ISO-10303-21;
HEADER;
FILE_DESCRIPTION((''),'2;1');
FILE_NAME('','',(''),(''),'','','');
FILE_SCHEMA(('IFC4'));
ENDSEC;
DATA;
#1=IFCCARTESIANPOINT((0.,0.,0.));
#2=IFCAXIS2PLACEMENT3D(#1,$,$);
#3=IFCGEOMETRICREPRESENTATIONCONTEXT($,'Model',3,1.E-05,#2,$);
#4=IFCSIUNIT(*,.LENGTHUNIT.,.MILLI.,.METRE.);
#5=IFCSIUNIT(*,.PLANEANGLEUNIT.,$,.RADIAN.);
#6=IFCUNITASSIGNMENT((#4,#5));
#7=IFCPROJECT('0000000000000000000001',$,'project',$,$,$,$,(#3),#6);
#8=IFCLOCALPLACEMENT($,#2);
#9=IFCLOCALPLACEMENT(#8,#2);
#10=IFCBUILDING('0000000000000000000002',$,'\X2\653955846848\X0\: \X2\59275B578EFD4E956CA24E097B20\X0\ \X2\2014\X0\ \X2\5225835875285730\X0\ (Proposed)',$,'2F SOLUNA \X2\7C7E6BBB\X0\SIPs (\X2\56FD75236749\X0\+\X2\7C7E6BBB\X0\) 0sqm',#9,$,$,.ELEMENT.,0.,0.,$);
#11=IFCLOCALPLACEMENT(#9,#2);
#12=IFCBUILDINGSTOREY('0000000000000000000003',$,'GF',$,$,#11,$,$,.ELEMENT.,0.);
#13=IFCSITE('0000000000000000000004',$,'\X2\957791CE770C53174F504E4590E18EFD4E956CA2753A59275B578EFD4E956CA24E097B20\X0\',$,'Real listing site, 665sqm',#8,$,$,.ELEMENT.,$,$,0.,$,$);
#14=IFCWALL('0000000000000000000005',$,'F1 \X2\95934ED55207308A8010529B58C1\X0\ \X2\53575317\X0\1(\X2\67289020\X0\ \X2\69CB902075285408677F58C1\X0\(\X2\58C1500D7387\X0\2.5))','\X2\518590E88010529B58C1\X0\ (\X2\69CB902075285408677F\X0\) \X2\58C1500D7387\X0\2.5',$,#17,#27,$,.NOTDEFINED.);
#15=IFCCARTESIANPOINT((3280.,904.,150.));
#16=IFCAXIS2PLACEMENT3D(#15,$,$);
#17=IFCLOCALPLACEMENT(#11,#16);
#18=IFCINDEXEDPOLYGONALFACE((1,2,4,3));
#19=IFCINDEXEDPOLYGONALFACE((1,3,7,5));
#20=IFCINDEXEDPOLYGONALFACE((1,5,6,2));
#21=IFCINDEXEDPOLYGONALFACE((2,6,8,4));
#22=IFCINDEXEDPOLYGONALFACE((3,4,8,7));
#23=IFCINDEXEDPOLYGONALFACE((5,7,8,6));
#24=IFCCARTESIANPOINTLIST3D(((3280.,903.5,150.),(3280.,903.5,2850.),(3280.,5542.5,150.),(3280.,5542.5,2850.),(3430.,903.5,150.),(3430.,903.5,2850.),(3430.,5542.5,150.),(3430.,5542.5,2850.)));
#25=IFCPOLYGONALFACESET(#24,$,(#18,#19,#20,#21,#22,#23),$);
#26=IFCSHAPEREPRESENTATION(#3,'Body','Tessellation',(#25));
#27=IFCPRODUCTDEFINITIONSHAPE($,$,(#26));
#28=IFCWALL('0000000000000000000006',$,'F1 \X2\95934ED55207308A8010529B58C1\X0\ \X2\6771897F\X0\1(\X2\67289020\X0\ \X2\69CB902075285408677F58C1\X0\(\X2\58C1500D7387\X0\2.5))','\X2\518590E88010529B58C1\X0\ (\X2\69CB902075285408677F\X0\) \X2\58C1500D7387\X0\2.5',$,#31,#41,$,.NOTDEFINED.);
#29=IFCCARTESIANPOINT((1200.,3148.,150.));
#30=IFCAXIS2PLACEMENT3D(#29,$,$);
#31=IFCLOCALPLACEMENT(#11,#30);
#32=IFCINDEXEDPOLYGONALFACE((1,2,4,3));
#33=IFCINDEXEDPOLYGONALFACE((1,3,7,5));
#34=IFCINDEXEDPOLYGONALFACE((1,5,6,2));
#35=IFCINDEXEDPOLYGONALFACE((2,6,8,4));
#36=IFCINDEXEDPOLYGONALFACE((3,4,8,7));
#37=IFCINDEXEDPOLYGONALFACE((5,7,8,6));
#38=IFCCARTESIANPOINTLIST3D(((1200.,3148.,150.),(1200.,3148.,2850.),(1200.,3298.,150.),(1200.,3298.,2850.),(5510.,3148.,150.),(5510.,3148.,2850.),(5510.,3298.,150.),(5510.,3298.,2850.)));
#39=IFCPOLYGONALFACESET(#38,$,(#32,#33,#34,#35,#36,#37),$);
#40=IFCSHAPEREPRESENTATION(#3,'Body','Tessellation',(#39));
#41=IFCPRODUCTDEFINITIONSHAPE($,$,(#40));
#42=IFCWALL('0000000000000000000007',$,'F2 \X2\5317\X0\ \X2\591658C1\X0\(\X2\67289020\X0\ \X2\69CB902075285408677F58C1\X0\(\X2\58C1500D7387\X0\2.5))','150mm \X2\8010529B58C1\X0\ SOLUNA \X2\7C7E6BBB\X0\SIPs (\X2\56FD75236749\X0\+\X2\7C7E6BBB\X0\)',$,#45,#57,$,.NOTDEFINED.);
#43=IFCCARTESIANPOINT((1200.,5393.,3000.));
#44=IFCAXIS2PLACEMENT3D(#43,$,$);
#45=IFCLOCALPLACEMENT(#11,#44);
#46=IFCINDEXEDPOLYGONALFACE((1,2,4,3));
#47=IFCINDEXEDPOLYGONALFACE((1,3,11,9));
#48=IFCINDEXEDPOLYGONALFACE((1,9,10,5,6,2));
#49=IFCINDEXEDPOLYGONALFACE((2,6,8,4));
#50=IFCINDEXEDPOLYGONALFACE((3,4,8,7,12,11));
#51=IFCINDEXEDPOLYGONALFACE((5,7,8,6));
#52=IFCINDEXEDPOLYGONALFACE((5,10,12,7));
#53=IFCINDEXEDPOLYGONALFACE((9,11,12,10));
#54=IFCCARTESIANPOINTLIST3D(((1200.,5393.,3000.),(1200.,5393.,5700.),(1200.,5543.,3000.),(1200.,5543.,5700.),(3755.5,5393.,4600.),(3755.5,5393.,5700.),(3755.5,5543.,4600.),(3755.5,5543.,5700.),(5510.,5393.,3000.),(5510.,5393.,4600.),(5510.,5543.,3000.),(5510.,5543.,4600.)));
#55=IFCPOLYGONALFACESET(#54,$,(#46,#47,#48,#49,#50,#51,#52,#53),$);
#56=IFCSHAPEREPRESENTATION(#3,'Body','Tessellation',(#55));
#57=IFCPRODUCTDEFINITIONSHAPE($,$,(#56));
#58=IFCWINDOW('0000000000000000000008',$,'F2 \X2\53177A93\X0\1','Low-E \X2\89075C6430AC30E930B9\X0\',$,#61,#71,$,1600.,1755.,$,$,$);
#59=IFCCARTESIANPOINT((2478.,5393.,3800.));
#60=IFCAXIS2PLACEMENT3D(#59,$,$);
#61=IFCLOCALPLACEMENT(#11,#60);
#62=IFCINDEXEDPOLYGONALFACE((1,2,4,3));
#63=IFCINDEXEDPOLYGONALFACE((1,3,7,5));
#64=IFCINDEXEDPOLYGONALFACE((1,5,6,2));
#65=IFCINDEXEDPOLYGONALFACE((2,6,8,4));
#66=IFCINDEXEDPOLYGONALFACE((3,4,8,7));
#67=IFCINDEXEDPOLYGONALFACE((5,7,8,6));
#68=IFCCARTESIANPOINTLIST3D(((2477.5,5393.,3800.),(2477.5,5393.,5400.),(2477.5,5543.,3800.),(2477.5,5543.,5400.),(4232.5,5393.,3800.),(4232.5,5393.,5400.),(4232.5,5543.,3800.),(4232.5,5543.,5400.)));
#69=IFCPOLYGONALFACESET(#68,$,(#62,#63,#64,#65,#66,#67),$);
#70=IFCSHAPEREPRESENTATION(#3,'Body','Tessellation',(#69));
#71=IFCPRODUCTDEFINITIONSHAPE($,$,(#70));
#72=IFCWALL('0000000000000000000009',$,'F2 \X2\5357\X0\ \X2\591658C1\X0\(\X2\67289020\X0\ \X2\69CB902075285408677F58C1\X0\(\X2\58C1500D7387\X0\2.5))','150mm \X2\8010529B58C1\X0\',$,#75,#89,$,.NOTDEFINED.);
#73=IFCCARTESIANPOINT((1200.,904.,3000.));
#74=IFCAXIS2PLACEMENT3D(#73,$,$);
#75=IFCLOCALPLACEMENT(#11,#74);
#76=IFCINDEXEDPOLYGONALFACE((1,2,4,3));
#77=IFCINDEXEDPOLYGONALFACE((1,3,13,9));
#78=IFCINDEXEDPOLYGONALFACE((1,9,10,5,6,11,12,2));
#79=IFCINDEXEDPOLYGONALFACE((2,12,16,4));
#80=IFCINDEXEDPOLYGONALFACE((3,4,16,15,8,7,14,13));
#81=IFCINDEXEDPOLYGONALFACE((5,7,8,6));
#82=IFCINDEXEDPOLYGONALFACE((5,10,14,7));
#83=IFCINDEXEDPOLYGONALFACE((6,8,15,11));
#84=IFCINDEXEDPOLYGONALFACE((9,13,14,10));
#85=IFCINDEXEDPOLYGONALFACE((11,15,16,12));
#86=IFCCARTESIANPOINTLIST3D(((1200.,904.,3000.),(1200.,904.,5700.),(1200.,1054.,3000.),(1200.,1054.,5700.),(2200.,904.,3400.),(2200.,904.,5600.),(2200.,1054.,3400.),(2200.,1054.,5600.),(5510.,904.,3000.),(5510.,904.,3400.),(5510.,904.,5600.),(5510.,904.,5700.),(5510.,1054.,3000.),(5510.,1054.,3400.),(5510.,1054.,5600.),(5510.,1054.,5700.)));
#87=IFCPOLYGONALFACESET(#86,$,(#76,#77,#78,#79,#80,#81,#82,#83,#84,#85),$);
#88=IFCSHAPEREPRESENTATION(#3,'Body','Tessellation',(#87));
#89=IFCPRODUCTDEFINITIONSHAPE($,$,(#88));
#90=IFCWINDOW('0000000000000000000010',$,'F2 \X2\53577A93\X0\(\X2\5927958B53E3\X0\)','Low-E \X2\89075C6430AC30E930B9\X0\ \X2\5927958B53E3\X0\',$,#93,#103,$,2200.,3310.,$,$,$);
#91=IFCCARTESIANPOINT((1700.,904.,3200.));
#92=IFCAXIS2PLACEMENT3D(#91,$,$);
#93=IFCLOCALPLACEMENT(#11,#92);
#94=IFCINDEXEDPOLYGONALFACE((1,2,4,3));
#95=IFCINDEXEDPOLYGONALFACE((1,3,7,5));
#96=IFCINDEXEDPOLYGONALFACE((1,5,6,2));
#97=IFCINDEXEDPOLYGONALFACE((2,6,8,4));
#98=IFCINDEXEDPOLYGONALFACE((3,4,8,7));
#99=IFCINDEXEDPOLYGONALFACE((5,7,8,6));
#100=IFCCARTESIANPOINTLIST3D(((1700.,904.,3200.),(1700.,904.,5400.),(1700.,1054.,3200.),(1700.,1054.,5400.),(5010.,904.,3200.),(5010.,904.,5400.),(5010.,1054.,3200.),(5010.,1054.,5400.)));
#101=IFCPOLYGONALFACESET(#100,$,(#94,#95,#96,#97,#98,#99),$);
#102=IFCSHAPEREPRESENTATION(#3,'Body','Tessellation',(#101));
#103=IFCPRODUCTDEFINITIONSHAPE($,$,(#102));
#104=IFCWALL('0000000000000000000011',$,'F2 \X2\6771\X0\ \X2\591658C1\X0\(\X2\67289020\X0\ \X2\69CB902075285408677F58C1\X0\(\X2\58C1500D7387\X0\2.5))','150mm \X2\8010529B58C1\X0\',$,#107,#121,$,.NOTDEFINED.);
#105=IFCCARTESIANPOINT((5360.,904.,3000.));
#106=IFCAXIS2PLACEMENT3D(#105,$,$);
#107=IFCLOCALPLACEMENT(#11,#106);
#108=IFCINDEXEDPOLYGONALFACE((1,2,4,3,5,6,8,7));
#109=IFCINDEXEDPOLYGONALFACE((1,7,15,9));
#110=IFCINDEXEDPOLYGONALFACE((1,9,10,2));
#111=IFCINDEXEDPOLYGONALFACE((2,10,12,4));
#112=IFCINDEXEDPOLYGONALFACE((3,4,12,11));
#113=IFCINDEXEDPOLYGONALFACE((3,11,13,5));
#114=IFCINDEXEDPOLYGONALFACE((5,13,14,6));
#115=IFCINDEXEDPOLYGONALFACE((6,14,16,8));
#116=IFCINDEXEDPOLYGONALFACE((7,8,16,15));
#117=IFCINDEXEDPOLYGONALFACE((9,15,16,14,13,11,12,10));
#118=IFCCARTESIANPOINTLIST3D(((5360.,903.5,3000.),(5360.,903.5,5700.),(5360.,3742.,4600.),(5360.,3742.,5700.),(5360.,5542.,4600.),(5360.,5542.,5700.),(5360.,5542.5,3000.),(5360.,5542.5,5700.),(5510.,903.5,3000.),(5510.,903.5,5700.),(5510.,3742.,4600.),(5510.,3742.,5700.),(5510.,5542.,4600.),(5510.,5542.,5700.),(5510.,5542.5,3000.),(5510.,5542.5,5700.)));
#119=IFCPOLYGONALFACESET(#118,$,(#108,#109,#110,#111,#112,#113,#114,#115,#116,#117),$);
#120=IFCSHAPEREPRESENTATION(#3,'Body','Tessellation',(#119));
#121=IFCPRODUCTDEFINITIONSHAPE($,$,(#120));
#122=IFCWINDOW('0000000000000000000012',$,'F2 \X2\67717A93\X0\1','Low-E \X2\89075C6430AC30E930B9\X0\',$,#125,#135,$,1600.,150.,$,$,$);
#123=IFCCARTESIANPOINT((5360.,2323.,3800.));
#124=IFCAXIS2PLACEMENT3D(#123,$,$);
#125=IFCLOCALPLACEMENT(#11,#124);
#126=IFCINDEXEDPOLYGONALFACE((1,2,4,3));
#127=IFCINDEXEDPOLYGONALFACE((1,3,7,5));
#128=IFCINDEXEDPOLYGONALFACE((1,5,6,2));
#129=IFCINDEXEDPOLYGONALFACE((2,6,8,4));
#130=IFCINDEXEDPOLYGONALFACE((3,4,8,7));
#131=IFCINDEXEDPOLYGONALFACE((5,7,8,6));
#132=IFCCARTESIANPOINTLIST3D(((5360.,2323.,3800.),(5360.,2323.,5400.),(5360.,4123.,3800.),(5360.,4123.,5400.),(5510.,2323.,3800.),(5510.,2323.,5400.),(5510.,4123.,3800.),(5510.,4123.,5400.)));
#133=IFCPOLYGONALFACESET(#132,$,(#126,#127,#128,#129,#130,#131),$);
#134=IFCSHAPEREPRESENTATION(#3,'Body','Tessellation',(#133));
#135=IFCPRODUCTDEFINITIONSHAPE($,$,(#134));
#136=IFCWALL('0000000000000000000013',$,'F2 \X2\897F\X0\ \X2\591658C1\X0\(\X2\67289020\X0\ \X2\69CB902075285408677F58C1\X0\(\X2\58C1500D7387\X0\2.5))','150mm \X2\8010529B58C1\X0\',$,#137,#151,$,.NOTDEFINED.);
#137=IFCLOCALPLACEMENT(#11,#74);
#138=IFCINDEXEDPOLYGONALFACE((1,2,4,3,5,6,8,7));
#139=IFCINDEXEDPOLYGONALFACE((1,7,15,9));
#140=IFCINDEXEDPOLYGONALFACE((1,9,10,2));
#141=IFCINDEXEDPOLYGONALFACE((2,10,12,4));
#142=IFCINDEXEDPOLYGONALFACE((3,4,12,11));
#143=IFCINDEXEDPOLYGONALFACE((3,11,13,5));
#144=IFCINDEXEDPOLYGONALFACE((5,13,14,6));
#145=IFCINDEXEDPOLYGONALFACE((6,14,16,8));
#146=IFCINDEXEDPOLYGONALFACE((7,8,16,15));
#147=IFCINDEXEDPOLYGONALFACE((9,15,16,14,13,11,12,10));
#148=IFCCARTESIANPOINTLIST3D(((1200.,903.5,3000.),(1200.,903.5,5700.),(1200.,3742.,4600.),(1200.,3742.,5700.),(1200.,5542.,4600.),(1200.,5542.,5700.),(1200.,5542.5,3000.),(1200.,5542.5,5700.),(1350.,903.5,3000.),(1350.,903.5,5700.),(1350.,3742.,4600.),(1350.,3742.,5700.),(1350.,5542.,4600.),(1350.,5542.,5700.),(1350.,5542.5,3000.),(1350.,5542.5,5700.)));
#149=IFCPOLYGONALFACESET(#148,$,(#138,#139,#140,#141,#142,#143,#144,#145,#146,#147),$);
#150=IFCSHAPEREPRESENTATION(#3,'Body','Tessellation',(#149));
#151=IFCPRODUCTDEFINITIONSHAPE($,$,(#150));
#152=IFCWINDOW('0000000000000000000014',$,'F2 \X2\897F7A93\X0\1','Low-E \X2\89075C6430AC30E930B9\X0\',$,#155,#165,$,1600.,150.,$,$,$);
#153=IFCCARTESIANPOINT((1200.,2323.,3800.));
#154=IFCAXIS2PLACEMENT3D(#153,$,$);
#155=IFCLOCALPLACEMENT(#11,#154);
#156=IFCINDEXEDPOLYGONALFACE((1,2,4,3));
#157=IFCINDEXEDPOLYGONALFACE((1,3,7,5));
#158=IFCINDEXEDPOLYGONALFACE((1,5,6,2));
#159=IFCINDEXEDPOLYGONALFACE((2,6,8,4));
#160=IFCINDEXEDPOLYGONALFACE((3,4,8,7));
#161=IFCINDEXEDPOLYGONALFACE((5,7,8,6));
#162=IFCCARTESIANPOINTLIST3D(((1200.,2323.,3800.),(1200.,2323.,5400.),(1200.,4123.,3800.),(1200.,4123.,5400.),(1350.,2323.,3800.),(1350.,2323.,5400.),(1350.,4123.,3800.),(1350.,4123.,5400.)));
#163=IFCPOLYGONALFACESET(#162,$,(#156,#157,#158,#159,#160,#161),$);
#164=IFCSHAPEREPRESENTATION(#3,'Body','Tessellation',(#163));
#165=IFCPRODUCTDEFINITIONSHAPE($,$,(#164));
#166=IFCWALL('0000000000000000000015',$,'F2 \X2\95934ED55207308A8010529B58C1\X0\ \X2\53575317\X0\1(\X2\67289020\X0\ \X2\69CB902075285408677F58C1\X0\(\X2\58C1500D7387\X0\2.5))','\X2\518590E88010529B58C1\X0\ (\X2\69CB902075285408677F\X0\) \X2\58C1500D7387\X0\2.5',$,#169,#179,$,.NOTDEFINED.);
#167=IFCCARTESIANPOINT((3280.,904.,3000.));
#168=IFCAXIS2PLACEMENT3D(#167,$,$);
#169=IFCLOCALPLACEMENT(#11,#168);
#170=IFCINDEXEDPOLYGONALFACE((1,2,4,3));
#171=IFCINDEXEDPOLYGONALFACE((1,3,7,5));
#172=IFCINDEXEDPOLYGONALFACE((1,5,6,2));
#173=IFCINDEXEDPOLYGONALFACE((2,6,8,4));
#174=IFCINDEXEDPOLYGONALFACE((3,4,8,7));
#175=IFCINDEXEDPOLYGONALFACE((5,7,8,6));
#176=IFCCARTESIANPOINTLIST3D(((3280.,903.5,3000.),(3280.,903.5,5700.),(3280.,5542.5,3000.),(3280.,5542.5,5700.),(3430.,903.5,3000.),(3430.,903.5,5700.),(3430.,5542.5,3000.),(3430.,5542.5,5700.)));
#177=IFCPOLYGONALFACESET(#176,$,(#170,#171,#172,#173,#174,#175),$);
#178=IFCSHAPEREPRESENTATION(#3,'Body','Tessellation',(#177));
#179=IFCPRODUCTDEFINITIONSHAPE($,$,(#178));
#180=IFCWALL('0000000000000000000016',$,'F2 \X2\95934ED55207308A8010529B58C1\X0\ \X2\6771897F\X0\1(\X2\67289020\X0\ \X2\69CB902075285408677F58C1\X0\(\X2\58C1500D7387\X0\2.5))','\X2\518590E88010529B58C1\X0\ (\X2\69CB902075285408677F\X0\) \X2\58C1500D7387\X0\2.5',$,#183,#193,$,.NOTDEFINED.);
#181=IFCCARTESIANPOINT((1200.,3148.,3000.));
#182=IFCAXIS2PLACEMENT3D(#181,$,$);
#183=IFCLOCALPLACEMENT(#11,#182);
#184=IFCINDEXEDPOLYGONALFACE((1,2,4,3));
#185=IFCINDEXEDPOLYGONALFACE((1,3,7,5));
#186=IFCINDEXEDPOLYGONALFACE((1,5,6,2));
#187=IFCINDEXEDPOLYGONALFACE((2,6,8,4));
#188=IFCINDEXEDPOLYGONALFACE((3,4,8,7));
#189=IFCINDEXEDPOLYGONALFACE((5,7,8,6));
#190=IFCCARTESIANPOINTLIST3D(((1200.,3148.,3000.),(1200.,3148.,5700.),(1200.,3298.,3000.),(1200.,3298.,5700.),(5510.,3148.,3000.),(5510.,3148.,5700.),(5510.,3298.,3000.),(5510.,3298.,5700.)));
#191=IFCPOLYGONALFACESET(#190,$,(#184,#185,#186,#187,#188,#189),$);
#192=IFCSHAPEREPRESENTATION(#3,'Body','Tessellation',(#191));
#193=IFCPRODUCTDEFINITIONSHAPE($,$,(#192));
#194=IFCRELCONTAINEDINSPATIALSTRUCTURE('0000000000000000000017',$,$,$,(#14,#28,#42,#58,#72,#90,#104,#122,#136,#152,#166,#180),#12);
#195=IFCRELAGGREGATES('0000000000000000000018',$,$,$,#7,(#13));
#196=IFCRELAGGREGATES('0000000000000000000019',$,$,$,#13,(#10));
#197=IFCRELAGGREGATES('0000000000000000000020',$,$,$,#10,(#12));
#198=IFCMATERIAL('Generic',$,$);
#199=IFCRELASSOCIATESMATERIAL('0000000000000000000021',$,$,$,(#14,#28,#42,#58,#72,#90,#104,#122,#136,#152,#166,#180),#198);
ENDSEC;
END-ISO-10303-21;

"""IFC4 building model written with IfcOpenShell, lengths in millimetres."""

from ifc_helpers import new_model, si_unit, frame, frame_2d, origin, place, context, project, spatial, rectangle, extrude, material, element, fill, save


model = new_model("IFC4")

# Units and contexts
model_context = context("Model", 3, precision=1e-05, world=origin())
ifc_project = project(units=[si_unit("LENGTHUNIT", "METRE", prefix="MILLI"), si_unit("PLANEANGLEUNIT", "RADIAN")], contexts=[model_context])

# Site, building, storey
site_placement = place(None, origin())
site = spatial("IfcSite", under=ifc_project, at=site_placement, Name="長野県北佐久郡軽井沢町大字軽井沢三笠", ObjectType="Real listing site, 665sqm", CompositionType="ELEMENT", RefElevation=0.0)
building_placement = place(site_placement, origin())
building = spatial("IfcBuilding", under=site, at=building_placement, Name="改善案: 大字軽井沢三笠 — 別荘用地 (Proposed)", ObjectType="2F SOLUNA 籾殻SIPs (国産杉+籾殻) 0sqm", CompositionType="ELEMENT", ElevationOfRefHeight=0.0, ElevationOfTerrain=0.0)
storey_placement = place(building_placement, origin())
storey = spatial("IfcBuildingStorey", under=building, at=storey_placement, Name="GF", CompositionType="ELEMENT", Elevation=0.0)

# Shared definitions
ifc_material_1 = material(Name="Generic")

# Walls
wall_1_placement = place(storey_placement, frame((3280.0, 904.0, 150.0)))
element("IfcWall", 1, at=wall_1_placement, inside=storey, material=ifc_material_1, Name="F1 間仕切り耐力壁 南北1(木造 構造用合板壁(壁倍率2.5))", Description="内部耐力壁 (構造用合板) 壁倍率2.5", PredefinedType="NOTDEFINED", context=model_context, shape_type="SweptSolid", body=[
    extrude(rectangle(XDim=150.0, YDim=4639.0, at=frame_2d((75.0, 2319.0))), frame((3280.0, 904.0, 150.0)), (0.0, 0.0, 1.0), 2700.0),
])
wall_2_placement = place(storey_placement, frame((1200.0, 3148.0, 150.0)))
element("IfcWall", 2, at=wall_2_placement, inside=storey, material=ifc_material_1, Name="F1 間仕切り耐力壁 東西1(木造 構造用合板壁(壁倍率2.5))", Description="内部耐力壁 (構造用合板) 壁倍率2.5", PredefinedType="NOTDEFINED", context=model_context, shape_type="SweptSolid", body=[
    extrude(rectangle(XDim=4310.0, YDim=150.0, at=frame_2d((2155.0, 75.0))), frame((1200.0, 3148.0, 150.0)), (0.0, 0.0, 1.0), 2700.0),
])

# Walls, openings, windows
wall_3_placement = place(storey_placement, frame((1200.0, 5393.0, 3000.0)))
wall_3 = element("IfcWall", 3, at=wall_3_placement, inside=storey, material=ifc_material_1, Name="F2 北 外壁(木造 構造用合板壁(壁倍率2.5))", Description="150mm 耐力壁 SOLUNA 籾殻SIPs (国産杉+籾殻)", PredefinedType="NOTDEFINED", context=model_context, shape_type="SweptSolid", body=[
    extrude(rectangle(XDim=4310.0, YDim=150.0, at=frame_2d((2155.0, 75.0))), frame((1200.0, 5393.0, 3000.0)), (0.0, 0.0, 1.0), 2700.0),
])
opening_1_placement = place(storey_placement, frame((2478.0, 5393.0, 3800.0)))
opening_1 = element("IfcOpeningElement", 4, at=opening_1_placement, cuts=wall_3, PredefinedType="NOTDEFINED", context=model_context, shape_type="SweptSolid", body=[
    extrude(rectangle(XDim=1755.0, YDim=150.0, at=frame_2d((877.0, 75.0))), frame((2478.0, 5393.0, 3800.0)), (0.0, 0.0, 1.0), 1600.0),
])
window_1_placement = place(storey_placement, frame((2478.0, 5393.0, 3800.0)))
window_1 = element("IfcWindow", 5, at=window_1_placement, inside=storey, material=ifc_material_1, Name="F2 北窓1", Description="Low-E 複層ガラス", OverallHeight=1600.0, OverallWidth=1755.0, context=model_context, shape_type="SweptSolid", body=[
    extrude(rectangle(XDim=1755.0, YDim=150.0, at=frame_2d((877.0, 75.0))), frame((2478.0, 5393.0, 3800.0)), (0.0, 0.0, 1.0), 1600.0),
])
fill(opening_1, window_1)
wall_4_placement = place(storey_placement, frame((1200.0, 904.0, 3000.0)))
wall_4 = element("IfcWall", 6, at=wall_4_placement, inside=storey, material=ifc_material_1, Name="F2 南 外壁(木造 構造用合板壁(壁倍率2.5))", Description="150mm 耐力壁", PredefinedType="NOTDEFINED", context=model_context, shape_type="SweptSolid", body=[
    extrude(rectangle(XDim=4310.0, YDim=150.0, at=frame_2d((2155.0, 75.0))), frame((1200.0, 904.0, 3000.0)), (0.0, 0.0, 1.0), 2700.0),
])
opening_2_placement = place(storey_placement, frame((1700.0, 904.0, 3200.0)))
opening_2 = element("IfcOpeningElement", 7, at=opening_2_placement, cuts=wall_4, PredefinedType="NOTDEFINED", context=model_context, shape_type="SweptSolid", body=[
    extrude(rectangle(XDim=3310.0, YDim=150.0, at=frame_2d((1655.0, 75.0))), frame((1700.0, 904.0, 3200.0)), (0.0, 0.0, 1.0), 2200.0),
])
window_2_placement = place(storey_placement, frame((1700.0, 904.0, 3200.0)))
window_2 = element("IfcWindow", 8, at=window_2_placement, inside=storey, material=ifc_material_1, Name="F2 南窓(大開口)", Description="Low-E 複層ガラス 大開口", OverallHeight=2200.0, OverallWidth=3310.0, context=model_context, shape_type="SweptSolid", body=[
    extrude(rectangle(XDim=3310.0, YDim=150.0, at=frame_2d((1655.0, 75.0))), frame((1700.0, 904.0, 3200.0)), (0.0, 0.0, 1.0), 2200.0),
])
fill(opening_2, window_2)
wall_5_placement = place(storey_placement, frame((5360.0, 904.0, 3000.0)))
wall_5 = element("IfcWall", 9, at=wall_5_placement, inside=storey, material=ifc_material_1, Name="F2 東 外壁(木造 構造用合板壁(壁倍率2.5))", Description="150mm 耐力壁", PredefinedType="NOTDEFINED", context=model_context, shape_type="SweptSolid", body=[
    extrude(rectangle(XDim=150.0, YDim=4639.0, at=frame_2d((75.0, 2319.0))), frame((5360.0, 904.0, 3000.0)), (0.0, 0.0, 1.0), 2700.0),
])
opening_3_placement = place(storey_placement, frame((5360.0, 2323.0, 3800.0)))
opening_3 = element("IfcOpeningElement", 10, at=opening_3_placement, cuts=wall_5, PredefinedType="NOTDEFINED", context=model_context, shape_type="SweptSolid", body=[
    extrude(rectangle(XDim=150.0, YDim=1800.0, at=frame_2d((75.0, 900.0))), frame((5360.0, 2323.0, 3800.0)), (0.0, 0.0, 1.0), 1600.0),
])
window_3_placement = place(storey_placement, frame((5360.0, 2323.0, 3800.0)))
window_3 = element("IfcWindow", 11, at=window_3_placement, inside=storey, material=ifc_material_1, Name="F2 東窓1", Description="Low-E 複層ガラス", OverallHeight=1600.0, OverallWidth=150.0, context=model_context, shape_type="SweptSolid", body=[
    extrude(rectangle(XDim=150.0, YDim=1800.0, at=frame_2d((75.0, 900.0))), frame((5360.0, 2323.0, 3800.0)), (0.0, 0.0, 1.0), 1600.0),
])
fill(opening_3, window_3)
wall_6_placement = place(storey_placement, frame((1200.0, 904.0, 3000.0)))
wall_6 = element("IfcWall", 12, at=wall_6_placement, inside=storey, material=ifc_material_1, Name="F2 西 外壁(木造 構造用合板壁(壁倍率2.5))", Description="150mm 耐力壁", PredefinedType="NOTDEFINED", context=model_context, shape_type="SweptSolid", body=[
    extrude(rectangle(XDim=150.0, YDim=4639.0, at=frame_2d((75.0, 2319.0))), frame((1200.0, 904.0, 3000.0)), (0.0, 0.0, 1.0), 2700.0),
])
opening_4_placement = place(storey_placement, frame((1200.0, 2323.0, 3800.0)))
opening_4 = element("IfcOpeningElement", 13, at=opening_4_placement, cuts=wall_6, PredefinedType="NOTDEFINED", context=model_context, shape_type="SweptSolid", body=[
    extrude(rectangle(XDim=150.0, YDim=1800.0, at=frame_2d((75.0, 900.0))), frame((1200.0, 2323.0, 3800.0)), (0.0, 0.0, 1.0), 1600.0),
])
window_4_placement = place(storey_placement, frame((1200.0, 2323.0, 3800.0)))
window_4 = element("IfcWindow", 14, at=window_4_placement, inside=storey, material=ifc_material_1, Name="F2 西窓1", Description="Low-E 複層ガラス", OverallHeight=1600.0, OverallWidth=150.0, context=model_context, shape_type="SweptSolid", body=[
    extrude(rectangle(XDim=150.0, YDim=1800.0, at=frame_2d((75.0, 900.0))), frame((1200.0, 2323.0, 3800.0)), (0.0, 0.0, 1.0), 1600.0),
])
fill(opening_4, window_4)

# Walls
wall_7_placement = place(storey_placement, frame((3280.0, 904.0, 3000.0)))
element("IfcWall", 15, at=wall_7_placement, inside=storey, material=ifc_material_1, Name="F2 間仕切り耐力壁 南北1(木造 構造用合板壁(壁倍率2.5))", Description="内部耐力壁 (構造用合板) 壁倍率2.5", PredefinedType="NOTDEFINED", context=model_context, shape_type="SweptSolid", body=[
    extrude(rectangle(XDim=150.0, YDim=4639.0, at=frame_2d((75.0, 2319.0))), frame((3280.0, 904.0, 3000.0)), (0.0, 0.0, 1.0), 2700.0),
])
wall_8_placement = place(storey_placement, frame((1200.0, 3148.0, 3000.0)))
element("IfcWall", 16, at=wall_8_placement, inside=storey, material=ifc_material_1, Name="F2 間仕切り耐力壁 東西1(木造 構造用合板壁(壁倍率2.5))", Description="内部耐力壁 (構造用合板) 壁倍率2.5", PredefinedType="NOTDEFINED", context=model_context, shape_type="SweptSolid", body=[
    extrude(rectangle(XDim=4310.0, YDim=150.0, at=frame_2d((2155.0, 75.0))), frame((1200.0, 3148.0, 3000.0)), (0.0, 0.0, 1.0), 2700.0),
])

save(model, "model.ifc")
